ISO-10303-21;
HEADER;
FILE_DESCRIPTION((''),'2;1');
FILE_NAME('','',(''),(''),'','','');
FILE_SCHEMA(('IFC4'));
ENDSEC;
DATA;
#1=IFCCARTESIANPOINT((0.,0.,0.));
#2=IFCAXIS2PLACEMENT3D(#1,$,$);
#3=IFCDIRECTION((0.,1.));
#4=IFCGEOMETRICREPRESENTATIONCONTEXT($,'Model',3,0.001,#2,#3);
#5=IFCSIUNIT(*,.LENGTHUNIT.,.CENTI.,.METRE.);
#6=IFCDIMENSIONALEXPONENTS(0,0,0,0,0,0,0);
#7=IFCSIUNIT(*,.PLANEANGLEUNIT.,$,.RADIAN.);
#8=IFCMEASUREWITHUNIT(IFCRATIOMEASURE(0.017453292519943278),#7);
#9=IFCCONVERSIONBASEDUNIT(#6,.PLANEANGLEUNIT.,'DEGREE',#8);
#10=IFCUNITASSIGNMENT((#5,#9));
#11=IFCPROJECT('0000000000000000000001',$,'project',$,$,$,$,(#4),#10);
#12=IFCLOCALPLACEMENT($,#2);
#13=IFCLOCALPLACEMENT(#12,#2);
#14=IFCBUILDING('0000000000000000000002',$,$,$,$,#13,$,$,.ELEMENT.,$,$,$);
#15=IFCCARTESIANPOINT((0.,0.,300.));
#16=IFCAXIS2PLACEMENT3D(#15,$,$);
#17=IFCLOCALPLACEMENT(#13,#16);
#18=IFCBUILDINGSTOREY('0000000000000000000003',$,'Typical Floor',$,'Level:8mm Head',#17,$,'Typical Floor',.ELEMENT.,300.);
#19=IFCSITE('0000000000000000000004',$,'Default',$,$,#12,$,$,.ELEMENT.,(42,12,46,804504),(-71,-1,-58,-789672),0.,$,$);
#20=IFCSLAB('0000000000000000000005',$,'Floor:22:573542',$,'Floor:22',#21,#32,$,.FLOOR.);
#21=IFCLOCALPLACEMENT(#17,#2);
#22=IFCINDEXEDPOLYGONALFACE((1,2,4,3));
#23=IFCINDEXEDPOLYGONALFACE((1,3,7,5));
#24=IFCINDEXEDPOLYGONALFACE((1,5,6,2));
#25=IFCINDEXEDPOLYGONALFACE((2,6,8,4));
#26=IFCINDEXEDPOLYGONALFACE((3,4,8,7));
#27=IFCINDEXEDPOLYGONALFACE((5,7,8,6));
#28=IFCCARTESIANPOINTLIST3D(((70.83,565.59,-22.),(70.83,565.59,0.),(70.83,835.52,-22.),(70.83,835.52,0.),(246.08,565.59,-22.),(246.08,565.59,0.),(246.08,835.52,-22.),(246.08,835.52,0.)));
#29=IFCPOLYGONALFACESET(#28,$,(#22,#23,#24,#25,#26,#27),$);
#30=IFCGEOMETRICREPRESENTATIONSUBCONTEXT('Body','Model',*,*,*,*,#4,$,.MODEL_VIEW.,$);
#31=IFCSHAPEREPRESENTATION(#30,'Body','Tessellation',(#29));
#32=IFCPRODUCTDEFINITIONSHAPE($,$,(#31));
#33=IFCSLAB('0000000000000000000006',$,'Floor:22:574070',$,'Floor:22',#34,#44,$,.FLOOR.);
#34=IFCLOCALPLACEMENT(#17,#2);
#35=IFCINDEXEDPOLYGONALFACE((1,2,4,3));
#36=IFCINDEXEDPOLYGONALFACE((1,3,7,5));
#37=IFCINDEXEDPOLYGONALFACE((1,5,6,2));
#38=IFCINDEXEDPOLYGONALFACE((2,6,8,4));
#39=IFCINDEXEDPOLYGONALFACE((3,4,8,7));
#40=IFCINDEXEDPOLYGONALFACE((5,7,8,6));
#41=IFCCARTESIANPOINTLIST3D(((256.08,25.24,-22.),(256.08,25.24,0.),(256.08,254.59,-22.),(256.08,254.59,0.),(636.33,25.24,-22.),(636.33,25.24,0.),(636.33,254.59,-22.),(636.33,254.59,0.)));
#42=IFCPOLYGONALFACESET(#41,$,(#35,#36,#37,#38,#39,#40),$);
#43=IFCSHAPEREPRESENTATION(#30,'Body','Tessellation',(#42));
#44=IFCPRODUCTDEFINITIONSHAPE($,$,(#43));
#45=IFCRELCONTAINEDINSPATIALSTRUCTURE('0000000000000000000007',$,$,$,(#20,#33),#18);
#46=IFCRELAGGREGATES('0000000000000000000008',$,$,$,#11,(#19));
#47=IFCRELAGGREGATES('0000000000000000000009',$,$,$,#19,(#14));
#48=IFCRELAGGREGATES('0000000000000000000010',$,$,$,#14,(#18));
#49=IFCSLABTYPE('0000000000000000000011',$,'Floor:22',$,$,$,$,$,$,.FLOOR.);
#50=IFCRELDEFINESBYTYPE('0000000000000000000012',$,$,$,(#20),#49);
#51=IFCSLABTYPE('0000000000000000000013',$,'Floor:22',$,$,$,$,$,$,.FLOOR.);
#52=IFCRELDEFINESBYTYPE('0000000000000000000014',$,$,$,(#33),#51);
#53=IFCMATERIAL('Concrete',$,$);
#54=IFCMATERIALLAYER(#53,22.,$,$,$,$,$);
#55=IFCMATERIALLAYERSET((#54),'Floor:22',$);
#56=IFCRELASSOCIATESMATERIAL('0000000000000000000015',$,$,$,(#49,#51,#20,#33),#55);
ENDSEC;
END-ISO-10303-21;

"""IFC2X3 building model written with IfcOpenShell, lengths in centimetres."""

from ifc_helpers import new_model, entity, si_unit, converted_unit, direction, frame, frame_2d, origin, place, context, subcontext, project, spatial, rectangle, extrude, material, layer, layer_set, layer_usage, type_object, element, save


model = new_model("IFC2X3")

# Units and contexts
model_context = context("Model", 3, precision=0.001, world=origin(), true_north=direction((0.0, 1.0)))
body_context = subcontext(model_context, "Body", "Model", "MODEL_VIEW")
ifc_project = project(units=[si_unit("LENGTHUNIT", "METRE", prefix="CENTI"), converted_unit("PLANEANGLEUNIT", "DEGREE", entity("IfcRatioMeasure", 0.017453292519943278), si_unit("PLANEANGLEUNIT", "RADIAN"), dimensions=[0, 0, 0, 0, 0, 0, 0])], contexts=[model_context])

# Site, building, storey
site_placement = place(None, origin())
site = spatial("IfcSite", under=ifc_project, at=site_placement, Name="Default", CompositionType="ELEMENT", RefLatitude=(42, 12, 46, 804504), RefLongitude=(-71, -1, -58, -789672), RefElevation=0.0)
building_placement = place(site_placement, origin())
building = spatial("IfcBuilding", under=site, at=building_placement, CompositionType="ELEMENT")
storey_placement = place(building_placement, frame((0.0, 0.0, 300.0)))
storey = spatial("IfcBuildingStorey", under=building, at=storey_placement, Name="Typical Floor", ObjectType="Level:8mm Head", LongName="Typical Floor", CompositionType="ELEMENT", Elevation=300.0)

# Shared definitions
ifc_material = material(Name="Concrete")

# Slabs
ifc_layer = layer(ifc_material, 22.0)
ifc_layer_set = layer_set([ifc_layer], Name="Floor:22")
ifc_layer_usage_1 = layer_usage(ifc_layer_set, "AXIS3", "POSITIVE", 0.0)
slab_type_1 = type_object("IfcSlabType", Name="Floor:22", PredefinedType="FLOOR", material=ifc_layer_set)
slab_1_placement = place(storey_placement, origin())
element("IfcSlab", 1, at=slab_1_placement, inside=storey, type_object=slab_type_1, material=ifc_layer_usage_1, Name="Floor:22:573542", ObjectType="Floor:22", PredefinedType="FLOOR", context=body_context, shape_type="SweptSolid", body=[
    extrude(rectangle(XDim=269.93, YDim=175.25, at=frame_2d((0.0, 0.0), x_axis=(1.0, 0.0))), frame((158.46, 700.55, 0.0), z_axis=(0.0, 0.0, -1.0), x_axis=(0.0, 1.0, 0.0)), (0.0, 0.0, 1.0), 22.0),
])
ifc_layer_usage_2 = layer_usage(ifc_layer_set, "AXIS3", "POSITIVE", 0.0)
slab_type_2 = type_object("IfcSlabType", Name="Floor:22", PredefinedType="FLOOR", material=ifc_layer_set)
slab_2_placement = place(storey_placement, origin())
element("IfcSlab", 2, at=slab_2_placement, inside=storey, type_object=slab_type_2, material=ifc_layer_usage_2, Name="Floor:22:574070", ObjectType="Floor:22", PredefinedType="FLOOR", context=body_context, shape_type="SweptSolid", body=[
    extrude(rectangle(XDim=229.35, YDim=380.25, at=frame_2d((0.0, 0.0), x_axis=(1.0, 0.0))), frame((446.21, 139.91, 0.0), z_axis=(0.0, 0.0, -1.0), x_axis=(0.0, 1.0, 0.0)), (0.0, 0.0, 1.0), 22.0),
])

save(model, "model.ifc")
